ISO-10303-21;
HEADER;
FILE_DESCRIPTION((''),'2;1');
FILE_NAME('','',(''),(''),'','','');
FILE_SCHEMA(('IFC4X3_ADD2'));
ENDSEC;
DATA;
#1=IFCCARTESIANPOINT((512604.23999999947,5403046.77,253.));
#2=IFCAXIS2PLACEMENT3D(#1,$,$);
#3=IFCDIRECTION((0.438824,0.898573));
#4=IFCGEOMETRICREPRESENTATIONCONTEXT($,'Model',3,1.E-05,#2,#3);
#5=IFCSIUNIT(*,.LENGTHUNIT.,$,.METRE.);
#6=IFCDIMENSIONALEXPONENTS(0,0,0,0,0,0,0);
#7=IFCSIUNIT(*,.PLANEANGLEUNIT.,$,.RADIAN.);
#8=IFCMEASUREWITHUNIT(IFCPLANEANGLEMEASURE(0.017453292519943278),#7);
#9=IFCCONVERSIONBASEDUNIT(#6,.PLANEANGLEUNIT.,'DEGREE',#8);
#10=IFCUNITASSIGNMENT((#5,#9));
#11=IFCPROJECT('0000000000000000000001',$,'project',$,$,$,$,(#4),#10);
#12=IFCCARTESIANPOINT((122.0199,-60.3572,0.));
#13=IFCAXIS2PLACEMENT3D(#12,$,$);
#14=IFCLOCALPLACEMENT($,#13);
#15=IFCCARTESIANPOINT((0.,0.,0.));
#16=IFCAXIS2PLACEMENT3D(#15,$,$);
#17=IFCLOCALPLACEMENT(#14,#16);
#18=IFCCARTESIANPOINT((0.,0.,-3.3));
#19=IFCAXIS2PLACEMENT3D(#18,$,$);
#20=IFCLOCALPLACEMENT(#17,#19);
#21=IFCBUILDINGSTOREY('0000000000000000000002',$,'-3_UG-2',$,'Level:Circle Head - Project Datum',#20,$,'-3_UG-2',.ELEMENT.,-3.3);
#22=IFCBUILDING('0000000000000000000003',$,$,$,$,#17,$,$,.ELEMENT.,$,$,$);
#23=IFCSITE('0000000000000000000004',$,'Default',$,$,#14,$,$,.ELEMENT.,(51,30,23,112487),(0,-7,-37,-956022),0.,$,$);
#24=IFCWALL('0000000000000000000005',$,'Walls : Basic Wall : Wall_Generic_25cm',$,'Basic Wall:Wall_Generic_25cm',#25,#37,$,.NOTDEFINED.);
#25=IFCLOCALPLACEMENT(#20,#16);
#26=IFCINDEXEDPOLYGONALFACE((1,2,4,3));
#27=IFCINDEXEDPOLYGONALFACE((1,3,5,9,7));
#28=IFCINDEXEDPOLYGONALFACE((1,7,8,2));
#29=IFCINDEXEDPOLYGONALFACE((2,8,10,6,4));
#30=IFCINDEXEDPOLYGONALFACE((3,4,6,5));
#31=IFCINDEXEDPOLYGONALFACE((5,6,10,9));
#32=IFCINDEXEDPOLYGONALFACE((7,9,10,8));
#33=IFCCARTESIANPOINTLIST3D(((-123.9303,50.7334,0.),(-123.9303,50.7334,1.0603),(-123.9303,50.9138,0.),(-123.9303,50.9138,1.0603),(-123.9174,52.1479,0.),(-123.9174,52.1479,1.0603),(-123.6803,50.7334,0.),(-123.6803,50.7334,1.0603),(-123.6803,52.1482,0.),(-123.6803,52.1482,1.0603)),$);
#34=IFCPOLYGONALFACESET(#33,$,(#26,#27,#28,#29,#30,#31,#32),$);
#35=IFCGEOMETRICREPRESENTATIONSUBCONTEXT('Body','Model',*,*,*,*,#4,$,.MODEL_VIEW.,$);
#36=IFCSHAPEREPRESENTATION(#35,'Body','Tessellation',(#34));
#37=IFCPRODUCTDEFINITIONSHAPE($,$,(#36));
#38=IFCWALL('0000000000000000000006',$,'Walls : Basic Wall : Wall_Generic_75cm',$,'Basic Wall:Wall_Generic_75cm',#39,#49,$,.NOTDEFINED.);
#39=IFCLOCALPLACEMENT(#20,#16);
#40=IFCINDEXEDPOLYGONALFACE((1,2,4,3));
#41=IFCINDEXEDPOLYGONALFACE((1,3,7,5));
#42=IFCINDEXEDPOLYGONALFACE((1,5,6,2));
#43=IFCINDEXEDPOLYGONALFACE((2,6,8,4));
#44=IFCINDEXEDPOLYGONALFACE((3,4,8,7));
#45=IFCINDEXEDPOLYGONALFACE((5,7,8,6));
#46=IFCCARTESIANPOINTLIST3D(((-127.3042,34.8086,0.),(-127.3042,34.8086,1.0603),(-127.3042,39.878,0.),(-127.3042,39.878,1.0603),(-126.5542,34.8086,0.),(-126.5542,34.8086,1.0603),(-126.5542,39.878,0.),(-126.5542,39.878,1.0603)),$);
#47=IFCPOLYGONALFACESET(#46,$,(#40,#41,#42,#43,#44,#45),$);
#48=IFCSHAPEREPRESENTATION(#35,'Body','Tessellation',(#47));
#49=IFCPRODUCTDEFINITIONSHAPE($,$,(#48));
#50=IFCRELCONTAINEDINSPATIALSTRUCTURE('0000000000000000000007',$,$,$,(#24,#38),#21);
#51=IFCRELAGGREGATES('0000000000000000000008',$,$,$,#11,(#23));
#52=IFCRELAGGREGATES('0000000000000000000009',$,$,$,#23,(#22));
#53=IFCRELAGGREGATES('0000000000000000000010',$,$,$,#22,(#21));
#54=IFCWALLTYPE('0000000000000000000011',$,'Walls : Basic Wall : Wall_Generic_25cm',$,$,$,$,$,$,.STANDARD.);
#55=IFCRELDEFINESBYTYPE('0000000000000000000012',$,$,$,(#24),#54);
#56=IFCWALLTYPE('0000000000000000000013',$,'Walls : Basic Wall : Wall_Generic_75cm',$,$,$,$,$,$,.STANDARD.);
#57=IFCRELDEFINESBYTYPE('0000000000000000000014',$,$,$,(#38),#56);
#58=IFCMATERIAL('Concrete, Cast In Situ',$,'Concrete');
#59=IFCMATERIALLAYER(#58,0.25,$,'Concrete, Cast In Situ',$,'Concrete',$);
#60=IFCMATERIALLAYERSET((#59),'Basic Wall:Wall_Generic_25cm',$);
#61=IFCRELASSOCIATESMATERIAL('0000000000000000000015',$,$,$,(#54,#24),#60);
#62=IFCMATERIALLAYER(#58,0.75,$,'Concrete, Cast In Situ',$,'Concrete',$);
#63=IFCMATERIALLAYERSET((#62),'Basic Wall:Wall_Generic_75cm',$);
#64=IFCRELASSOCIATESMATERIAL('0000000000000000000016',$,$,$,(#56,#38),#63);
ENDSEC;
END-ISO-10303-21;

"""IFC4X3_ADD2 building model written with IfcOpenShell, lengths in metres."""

from ifc_helpers import new_model, entity, si_unit, converted_unit, direction, frame, frame_2d, origin, place, context, subcontext, project, spatial, polyline, rectangle, outline, extrude, clip, halfspace, bounded_halfspace, material, layer, layer_set, type_object, element, save


model = new_model("IFC4X3_ADD2")

# Units and contexts
model_context = context("Model", 3, precision=1e-05, world=frame((512604.23999999947, 5403046.77, 253.0)), true_north=direction((0.438824, 0.898573)))
body_context = subcontext(model_context, "Body", "Model", "MODEL_VIEW")
ifc_project = project(units=[si_unit("LENGTHUNIT", "METRE"), converted_unit("PLANEANGLEUNIT", "DEGREE", entity("IfcPlaneAngleMeasure", 0.017453292519943278), si_unit("PLANEANGLEUNIT", "RADIAN"), dimensions=[0, 0, 0, 0, 0, 0, 0])], contexts=[model_context])

# Site, building, storey
site_placement = place(None, frame((122.0199, -60.3572, 0.0)))
site = spatial("IfcSite", under=ifc_project, at=site_placement, Name="Default", CompositionType="ELEMENT", RefLatitude=(51, 30, 23, 112487), RefLongitude=(0, -7, -37, -956022), RefElevation=0.0)
building_placement = place(site_placement, origin())
building = spatial("IfcBuilding", under=site, at=building_placement, CompositionType="ELEMENT")
storey_placement = place(building_placement, frame((0.0, 0.0, -3.3)))
storey = spatial("IfcBuildingStorey", under=building, at=storey_placement, Name="-3_UG-2", ObjectType="Level:Circle Head - Project Datum", LongName="-3_UG-2", CompositionType="ELEMENT", Elevation=-3.3)

# Shared definitions
ifc_material_1 = material(Name="Concrete, Cast In Situ", Category="Concrete")

# Walls
ifc_layer_1 = layer(ifc_material_1, 0.25, Name="Concrete, Cast In Situ", Category="Concrete")
ifc_layer_set_1 = layer_set([ifc_layer_1], Name="Basic Wall:Wall_Generic_25cm")
wall_type_1 = type_object("IfcWallType", Name="Walls : Basic Wall : Wall_Generic_25cm", PredefinedType="STANDARD", material=ifc_layer_set_1)
wall_1_placement = place(storey_placement, frame((-123.8053, 50.7334, 0.0), z_axis=(0.0, 0.0, 1.0), x_axis=(0.0, 1.0, 0.0)))
element("IfcWall", 1, at=wall_1_placement, inside=storey, type_object=wall_type_1, material=ifc_layer_set_1, Name="Walls : Basic Wall : Wall_Generic_25cm", ObjectType="Basic Wall:Wall_Generic_25cm", PredefinedType="NOTDEFINED", context=body_context, shape_type="Clipping", body=[
    clip(clip(extrude(outline(polyline([(1.4149, -0.125), (1.4146, 0.112), (1.2946, 0.1133), (0.1804, 0.125), (0.0, 0.125), (0.0, -0.125), (1.4149, -0.125)])), origin(), (0.0, 0.0, 1.0), 1.0603), bounded_halfspace(frame((0.1804, 0.125, 0.0), z_axis=(-0.010506, -0.999945, 0.0), x_axis=(0.999945, -0.010506, 0.0)), True, frame((0.1804, 0.125, 0.0), z_axis=(-0.010506, -0.999945, 0.0), x_axis=(0.999945, -0.010506, 0.0)), polyline([(0.0, 0.0), (1.1142, 0.0), (1.2342, 0.0), (1.2342, 1.33), (0.0, 1.33), (0.0, 0.0)]))), halfspace(origin(), True)),
])
ifc_layer_2 = layer(ifc_material_1, 0.75, Name="Concrete, Cast In Situ", Category="Concrete")
ifc_layer_set_2 = layer_set([ifc_layer_2], Name="Basic Wall:Wall_Generic_75cm")
wall_type_2 = type_object("IfcWallType", Name="Walls : Basic Wall : Wall_Generic_75cm", PredefinedType="STANDARD", material=ifc_layer_set_2)
wall_2_placement = place(storey_placement, frame((-126.9292, 39.878, 0.0), z_axis=(0.0, 0.0, 1.0), x_axis=(0.0, -1.0, 0.0)))
element("IfcWall", 2, at=wall_2_placement, inside=storey, type_object=wall_type_2, material=ifc_layer_set_2, Name="Walls : Basic Wall : Wall_Generic_75cm", ObjectType="Basic Wall:Wall_Generic_75cm", PredefinedType="NOTDEFINED", context=body_context, shape_type="Clipping", body=[
    clip(extrude(rectangle(XDim=5.0695, YDim=0.75, at=frame_2d((2.5347, 0.0), x_axis=(-1.0, 0.0))), origin(), (0.0, 0.0, 1.0), 1.0603), halfspace(origin(), True)),
])

save(model, "model.ifc")
